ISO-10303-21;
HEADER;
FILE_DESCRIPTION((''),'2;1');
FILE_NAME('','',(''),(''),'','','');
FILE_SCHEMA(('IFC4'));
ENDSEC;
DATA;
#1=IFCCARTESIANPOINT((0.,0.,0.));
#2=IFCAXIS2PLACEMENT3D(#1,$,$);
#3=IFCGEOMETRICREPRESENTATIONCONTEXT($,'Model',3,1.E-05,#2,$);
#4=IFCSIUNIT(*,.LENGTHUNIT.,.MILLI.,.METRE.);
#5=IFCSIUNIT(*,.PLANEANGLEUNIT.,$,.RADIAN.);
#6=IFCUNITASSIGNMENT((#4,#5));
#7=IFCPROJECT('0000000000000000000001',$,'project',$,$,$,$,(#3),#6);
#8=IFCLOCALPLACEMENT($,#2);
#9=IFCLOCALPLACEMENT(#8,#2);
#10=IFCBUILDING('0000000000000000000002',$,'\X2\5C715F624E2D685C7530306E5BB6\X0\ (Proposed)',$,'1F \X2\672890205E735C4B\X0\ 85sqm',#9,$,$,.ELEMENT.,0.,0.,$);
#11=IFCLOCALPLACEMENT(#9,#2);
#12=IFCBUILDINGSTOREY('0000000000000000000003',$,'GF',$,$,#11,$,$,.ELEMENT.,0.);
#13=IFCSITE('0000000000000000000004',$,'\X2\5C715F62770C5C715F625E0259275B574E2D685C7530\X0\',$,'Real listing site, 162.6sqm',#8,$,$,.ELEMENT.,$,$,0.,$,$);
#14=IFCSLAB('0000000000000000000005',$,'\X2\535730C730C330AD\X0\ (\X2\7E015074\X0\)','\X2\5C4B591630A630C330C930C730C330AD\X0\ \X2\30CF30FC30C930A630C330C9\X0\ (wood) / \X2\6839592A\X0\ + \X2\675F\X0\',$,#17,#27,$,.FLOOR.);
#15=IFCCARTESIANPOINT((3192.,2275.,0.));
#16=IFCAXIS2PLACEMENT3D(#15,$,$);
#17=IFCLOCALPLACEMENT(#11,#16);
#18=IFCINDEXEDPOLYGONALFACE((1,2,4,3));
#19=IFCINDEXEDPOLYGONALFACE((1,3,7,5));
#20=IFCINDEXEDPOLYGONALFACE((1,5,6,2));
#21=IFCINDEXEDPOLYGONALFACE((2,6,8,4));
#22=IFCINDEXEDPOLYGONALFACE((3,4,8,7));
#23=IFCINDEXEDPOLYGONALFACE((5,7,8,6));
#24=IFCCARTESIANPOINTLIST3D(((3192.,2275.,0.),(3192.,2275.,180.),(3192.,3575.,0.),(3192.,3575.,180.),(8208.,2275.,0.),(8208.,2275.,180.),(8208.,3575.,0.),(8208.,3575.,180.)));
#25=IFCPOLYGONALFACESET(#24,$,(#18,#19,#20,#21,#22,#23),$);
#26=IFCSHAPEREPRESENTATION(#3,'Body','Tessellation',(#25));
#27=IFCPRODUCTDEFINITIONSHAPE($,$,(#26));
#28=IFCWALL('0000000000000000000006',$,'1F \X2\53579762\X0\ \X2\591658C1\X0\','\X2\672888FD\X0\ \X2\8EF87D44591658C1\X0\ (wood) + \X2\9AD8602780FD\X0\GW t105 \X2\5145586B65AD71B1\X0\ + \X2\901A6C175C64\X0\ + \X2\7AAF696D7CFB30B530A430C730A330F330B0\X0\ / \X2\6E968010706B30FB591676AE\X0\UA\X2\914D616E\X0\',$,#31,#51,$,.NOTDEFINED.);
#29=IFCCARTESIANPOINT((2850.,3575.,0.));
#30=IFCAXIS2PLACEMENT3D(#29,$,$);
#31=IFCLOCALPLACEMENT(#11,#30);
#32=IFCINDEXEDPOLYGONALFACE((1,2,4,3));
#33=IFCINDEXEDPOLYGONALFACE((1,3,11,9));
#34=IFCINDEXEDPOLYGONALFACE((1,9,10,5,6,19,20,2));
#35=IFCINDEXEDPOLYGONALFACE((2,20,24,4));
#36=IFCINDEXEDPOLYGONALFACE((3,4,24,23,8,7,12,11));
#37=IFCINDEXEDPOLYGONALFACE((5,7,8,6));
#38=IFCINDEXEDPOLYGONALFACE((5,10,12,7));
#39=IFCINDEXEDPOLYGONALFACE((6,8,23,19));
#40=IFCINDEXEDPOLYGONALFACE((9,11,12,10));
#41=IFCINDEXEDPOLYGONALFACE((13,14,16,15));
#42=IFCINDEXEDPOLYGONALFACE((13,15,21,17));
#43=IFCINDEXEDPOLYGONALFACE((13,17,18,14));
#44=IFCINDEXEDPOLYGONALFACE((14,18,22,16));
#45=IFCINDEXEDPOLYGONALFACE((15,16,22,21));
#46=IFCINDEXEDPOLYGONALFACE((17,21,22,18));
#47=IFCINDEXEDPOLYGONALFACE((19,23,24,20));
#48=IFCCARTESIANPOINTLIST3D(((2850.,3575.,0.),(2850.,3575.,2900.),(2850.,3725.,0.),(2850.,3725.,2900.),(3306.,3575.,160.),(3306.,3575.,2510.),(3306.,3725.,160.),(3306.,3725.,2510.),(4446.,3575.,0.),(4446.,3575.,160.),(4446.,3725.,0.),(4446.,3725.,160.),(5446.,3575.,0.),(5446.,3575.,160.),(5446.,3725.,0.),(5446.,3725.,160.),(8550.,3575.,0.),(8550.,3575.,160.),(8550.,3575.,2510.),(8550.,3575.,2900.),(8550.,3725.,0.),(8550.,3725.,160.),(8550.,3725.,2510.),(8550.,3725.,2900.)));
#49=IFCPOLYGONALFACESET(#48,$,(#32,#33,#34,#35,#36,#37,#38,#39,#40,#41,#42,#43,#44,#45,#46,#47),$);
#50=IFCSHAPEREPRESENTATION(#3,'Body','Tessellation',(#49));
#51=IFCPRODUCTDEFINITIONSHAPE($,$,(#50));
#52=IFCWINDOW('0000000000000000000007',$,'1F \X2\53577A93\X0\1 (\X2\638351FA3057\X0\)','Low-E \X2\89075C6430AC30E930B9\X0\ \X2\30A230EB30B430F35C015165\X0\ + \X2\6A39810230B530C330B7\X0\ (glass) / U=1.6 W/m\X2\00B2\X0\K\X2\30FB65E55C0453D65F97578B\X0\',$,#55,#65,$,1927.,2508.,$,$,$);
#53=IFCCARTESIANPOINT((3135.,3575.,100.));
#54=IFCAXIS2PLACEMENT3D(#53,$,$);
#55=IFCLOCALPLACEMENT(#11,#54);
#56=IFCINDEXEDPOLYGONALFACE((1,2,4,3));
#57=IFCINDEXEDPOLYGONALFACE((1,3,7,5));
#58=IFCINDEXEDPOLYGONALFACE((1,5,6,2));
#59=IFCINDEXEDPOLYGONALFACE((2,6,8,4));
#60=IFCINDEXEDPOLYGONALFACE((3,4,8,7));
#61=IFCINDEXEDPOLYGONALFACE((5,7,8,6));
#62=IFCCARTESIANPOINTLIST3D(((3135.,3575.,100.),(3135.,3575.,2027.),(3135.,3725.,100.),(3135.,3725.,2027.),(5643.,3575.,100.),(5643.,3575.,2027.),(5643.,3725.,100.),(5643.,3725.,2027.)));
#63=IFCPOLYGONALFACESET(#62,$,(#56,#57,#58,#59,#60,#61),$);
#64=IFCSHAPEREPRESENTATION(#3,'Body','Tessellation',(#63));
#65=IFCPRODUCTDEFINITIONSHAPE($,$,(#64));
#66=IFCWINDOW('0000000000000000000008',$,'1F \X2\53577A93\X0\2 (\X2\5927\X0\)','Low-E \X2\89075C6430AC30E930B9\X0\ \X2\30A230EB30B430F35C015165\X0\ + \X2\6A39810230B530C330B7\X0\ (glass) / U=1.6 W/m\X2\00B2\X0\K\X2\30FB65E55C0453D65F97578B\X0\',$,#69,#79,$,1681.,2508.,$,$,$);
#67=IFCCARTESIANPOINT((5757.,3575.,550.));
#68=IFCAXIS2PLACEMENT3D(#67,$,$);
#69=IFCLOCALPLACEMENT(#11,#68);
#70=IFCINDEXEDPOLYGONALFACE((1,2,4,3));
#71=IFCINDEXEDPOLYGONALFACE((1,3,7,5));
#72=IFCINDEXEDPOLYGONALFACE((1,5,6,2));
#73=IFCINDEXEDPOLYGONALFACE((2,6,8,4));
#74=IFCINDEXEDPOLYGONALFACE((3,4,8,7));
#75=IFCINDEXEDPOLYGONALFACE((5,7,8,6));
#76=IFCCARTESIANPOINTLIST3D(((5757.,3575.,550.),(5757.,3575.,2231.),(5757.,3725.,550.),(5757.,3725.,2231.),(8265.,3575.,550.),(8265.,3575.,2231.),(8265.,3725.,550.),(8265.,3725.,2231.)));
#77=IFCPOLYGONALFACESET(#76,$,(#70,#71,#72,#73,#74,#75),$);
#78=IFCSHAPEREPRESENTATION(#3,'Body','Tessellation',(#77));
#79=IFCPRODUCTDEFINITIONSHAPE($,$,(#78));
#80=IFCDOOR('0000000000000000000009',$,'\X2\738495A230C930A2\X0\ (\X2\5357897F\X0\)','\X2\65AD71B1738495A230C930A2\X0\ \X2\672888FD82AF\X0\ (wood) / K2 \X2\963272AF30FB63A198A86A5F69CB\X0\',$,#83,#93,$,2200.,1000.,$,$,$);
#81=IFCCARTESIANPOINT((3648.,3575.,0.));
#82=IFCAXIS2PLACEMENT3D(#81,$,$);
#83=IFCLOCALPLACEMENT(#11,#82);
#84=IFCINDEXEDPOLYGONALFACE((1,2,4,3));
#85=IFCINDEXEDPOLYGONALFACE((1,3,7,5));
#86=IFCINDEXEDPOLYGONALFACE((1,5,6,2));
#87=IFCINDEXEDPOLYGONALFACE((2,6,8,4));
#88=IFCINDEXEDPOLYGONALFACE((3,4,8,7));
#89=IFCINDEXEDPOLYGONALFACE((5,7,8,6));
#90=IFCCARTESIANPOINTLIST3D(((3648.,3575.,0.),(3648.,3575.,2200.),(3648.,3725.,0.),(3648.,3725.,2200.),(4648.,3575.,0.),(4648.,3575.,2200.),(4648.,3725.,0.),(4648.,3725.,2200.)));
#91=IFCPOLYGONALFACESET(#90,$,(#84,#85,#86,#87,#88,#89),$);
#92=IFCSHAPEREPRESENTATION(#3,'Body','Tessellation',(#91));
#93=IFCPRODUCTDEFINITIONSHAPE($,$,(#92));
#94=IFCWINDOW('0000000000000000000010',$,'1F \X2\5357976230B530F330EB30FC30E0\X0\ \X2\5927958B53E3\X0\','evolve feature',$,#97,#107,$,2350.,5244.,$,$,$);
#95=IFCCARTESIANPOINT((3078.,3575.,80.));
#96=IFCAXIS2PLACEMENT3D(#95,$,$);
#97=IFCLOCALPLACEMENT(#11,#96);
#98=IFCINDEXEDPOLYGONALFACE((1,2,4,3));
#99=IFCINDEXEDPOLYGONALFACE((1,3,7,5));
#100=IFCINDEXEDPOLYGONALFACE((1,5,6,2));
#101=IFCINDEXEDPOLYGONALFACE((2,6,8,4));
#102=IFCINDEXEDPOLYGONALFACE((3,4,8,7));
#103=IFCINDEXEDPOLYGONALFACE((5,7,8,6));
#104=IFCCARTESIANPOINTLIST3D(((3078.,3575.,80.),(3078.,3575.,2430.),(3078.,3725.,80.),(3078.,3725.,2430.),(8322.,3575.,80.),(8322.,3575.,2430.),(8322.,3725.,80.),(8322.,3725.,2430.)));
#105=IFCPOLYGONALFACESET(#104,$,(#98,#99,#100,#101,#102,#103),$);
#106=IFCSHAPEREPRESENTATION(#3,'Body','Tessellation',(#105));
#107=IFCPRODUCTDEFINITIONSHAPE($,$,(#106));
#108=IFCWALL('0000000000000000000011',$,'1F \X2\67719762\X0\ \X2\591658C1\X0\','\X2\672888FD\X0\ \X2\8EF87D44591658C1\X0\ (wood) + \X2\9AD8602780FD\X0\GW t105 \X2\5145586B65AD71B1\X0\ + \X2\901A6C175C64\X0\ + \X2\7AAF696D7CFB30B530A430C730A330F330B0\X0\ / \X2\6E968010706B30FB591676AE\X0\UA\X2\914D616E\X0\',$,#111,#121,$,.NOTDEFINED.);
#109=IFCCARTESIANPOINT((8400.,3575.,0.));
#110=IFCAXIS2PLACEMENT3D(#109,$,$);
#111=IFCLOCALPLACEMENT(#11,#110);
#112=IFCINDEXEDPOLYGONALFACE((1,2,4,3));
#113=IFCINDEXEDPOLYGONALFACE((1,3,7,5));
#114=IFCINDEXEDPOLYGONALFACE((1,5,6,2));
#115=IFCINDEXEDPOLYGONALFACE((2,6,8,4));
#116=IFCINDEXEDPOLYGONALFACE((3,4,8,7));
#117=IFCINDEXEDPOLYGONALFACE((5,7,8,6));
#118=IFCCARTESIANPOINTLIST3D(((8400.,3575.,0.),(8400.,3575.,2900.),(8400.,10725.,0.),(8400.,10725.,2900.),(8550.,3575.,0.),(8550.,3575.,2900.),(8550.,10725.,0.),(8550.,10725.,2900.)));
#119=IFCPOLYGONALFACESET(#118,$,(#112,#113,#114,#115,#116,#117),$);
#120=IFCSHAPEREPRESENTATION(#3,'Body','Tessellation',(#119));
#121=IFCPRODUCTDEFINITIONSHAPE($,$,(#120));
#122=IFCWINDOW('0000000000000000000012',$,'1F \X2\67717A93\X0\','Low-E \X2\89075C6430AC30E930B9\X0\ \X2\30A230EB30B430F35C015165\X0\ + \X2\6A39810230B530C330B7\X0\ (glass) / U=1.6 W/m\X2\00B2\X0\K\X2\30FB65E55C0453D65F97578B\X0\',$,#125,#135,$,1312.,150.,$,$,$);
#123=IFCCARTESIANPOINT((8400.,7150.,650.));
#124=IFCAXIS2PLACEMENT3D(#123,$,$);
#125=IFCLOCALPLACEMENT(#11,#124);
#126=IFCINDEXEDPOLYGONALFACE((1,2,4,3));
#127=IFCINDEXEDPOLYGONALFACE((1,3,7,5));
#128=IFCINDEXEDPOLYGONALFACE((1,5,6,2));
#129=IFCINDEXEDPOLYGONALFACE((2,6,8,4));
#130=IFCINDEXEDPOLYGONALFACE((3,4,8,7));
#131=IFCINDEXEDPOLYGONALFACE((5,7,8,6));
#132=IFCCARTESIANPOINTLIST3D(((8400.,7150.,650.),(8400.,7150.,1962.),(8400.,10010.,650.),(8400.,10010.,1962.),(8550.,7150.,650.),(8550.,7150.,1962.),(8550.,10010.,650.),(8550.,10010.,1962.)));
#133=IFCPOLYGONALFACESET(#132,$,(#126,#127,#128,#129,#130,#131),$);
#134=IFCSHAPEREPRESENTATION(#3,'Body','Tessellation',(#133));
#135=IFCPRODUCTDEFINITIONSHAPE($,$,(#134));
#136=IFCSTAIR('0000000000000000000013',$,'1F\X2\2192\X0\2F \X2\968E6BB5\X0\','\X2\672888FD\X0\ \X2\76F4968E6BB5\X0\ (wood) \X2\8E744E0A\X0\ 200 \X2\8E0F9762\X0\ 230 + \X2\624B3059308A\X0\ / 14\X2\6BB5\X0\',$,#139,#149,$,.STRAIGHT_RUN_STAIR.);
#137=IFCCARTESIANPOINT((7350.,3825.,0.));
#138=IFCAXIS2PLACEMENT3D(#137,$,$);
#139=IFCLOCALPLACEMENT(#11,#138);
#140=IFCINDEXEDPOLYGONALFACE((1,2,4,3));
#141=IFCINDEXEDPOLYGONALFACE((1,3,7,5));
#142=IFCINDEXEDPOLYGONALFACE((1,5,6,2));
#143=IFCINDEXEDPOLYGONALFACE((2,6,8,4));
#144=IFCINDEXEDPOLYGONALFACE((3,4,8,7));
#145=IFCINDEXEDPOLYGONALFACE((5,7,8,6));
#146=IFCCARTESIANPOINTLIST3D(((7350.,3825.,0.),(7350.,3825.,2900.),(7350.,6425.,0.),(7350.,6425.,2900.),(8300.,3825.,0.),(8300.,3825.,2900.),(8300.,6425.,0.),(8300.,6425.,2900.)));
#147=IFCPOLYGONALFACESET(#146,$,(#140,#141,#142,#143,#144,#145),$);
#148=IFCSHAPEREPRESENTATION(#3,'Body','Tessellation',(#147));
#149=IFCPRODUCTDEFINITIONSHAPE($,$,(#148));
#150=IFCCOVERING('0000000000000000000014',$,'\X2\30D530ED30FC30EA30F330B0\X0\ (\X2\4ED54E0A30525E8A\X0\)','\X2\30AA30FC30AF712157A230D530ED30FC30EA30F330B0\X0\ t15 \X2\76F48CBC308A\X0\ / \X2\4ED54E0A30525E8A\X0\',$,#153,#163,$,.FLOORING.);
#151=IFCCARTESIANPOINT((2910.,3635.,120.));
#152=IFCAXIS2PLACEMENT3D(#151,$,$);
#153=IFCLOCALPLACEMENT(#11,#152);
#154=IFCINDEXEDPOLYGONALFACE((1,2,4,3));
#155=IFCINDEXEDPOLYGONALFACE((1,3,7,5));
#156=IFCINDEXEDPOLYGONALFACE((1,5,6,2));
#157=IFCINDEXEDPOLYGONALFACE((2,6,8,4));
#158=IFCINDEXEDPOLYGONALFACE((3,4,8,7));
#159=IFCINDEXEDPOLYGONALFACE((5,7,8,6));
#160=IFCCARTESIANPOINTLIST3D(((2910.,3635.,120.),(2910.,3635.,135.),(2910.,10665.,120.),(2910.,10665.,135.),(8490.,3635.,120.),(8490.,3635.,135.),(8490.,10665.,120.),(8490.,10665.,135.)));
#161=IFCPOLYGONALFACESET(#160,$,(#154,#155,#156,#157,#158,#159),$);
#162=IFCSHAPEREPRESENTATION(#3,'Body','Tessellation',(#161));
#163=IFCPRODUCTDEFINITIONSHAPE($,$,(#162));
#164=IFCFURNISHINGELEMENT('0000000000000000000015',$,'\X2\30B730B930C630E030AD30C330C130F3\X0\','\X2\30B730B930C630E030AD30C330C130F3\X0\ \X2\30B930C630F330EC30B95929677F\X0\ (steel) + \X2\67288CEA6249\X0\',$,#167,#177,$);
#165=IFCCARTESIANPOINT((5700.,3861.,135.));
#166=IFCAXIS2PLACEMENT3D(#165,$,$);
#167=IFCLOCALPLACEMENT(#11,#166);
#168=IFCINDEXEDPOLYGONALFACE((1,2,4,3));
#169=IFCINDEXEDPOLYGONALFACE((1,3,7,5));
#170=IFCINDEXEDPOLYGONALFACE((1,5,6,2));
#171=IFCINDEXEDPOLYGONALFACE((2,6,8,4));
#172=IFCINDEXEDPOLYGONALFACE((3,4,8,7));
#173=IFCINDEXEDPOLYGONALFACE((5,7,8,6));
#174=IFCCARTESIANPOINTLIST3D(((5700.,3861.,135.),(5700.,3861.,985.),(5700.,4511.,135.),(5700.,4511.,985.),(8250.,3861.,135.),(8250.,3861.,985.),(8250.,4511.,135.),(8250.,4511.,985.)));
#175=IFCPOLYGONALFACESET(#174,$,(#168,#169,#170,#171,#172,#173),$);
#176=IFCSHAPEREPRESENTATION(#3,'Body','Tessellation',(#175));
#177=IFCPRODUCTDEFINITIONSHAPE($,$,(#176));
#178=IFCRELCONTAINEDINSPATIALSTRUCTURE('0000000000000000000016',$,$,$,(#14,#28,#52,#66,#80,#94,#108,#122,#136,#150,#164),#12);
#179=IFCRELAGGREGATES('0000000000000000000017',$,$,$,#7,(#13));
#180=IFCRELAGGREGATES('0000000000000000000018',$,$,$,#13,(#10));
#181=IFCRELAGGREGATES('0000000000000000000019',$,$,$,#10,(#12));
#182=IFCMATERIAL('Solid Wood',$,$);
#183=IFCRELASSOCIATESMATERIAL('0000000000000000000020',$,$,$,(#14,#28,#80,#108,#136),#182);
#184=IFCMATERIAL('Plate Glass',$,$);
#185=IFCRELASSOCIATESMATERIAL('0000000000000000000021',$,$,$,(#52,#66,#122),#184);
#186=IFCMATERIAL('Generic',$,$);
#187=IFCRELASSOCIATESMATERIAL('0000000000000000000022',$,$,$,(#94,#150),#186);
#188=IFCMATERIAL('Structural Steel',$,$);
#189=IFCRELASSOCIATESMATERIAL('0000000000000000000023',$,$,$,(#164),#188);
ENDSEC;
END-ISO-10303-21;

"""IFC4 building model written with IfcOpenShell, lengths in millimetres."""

from ifc_helpers import new_model, si_unit, frame, frame_2d, origin, place, context, project, spatial, rectangle, extrude, material, element, fill, save


model = new_model("IFC4")

# Units and contexts
model_context = context("Model", 3, precision=1e-05, world=origin())
ifc_project = project(units=[si_unit("LENGTHUNIT", "METRE", prefix="MILLI"), si_unit("PLANEANGLEUNIT", "RADIAN")], contexts=[model_context])

# Site, building, storey
site_placement = place(None, origin())
site = spatial("IfcSite", under=ifc_project, at=site_placement, Name="山形県山形市大字中桜田", ObjectType="Real listing site, 162.6sqm", CompositionType="ELEMENT", RefElevation=0.0)
building_placement = place(site_placement, origin())
building = spatial("IfcBuilding", under=site, at=building_placement, Name="山形中桜田の家 (Proposed)", ObjectType="1F 木造平屋 85sqm", CompositionType="ELEMENT", ElevationOfRefHeight=0.0, ElevationOfTerrain=0.0)
storey_placement = place(building_placement, origin())
storey = spatial("IfcBuildingStorey", under=building, at=storey_placement, Name="GF", CompositionType="ELEMENT", Elevation=0.0)

# Slab
ifc_material_1 = material(Name="Solid Wood")
slab_1_placement = place(storey_placement, frame((3192.0, 2275.0, 0.0)))
element("IfcSlab", 1, at=slab_1_placement, inside=storey, material=ifc_material_1, Name="南デッキ (縁側)", Description="屋外ウッドデッキ ハードウッド (wood) / 根太 + 束", PredefinedType="FLOOR", context=model_context, shape_type="SweptSolid", body=[
    extrude(rectangle(XDim=5016.0, YDim=1300.0, at=frame_2d((2508.0, 650.0))), frame((3192.0, 2275.0, 0.0)), (0.0, 0.0, 1.0), 180.0),
])
ifc_material_2 = material(Name="Generic")

# Wall, openings, windows, door
wall_1_placement = place(storey_placement, frame((2850.0, 3575.0, 0.0)))
wall_1 = element("IfcWall", 2, at=wall_1_placement, inside=storey, material=ifc_material_1, Name="1F 南面 外壁", Description="木製 軸組外壁 (wood) + 高性能GW t105 充填断熱 + 通気層 + 窯業系サイディング / 準耐火・外皮UA配慮", PredefinedType="NOTDEFINED", context=model_context, shape_type="SweptSolid", body=[
    extrude(rectangle(XDim=5700.0, YDim=150.0, at=frame_2d((2850.0, 75.0))), frame((2850.0, 3575.0, 0.0)), (0.0, 0.0, 1.0), 2900.0),
])
opening_1_placement = place(storey_placement, frame((3135.0, 3575.0, 100.0)))
opening_1 = element("IfcOpeningElement", 3, at=opening_1_placement, cuts=wall_1, PredefinedType="NOTDEFINED", context=model_context, shape_type="SweptSolid", body=[
    extrude(rectangle(XDim=2508.0, YDim=150.0, at=frame_2d((1254.0, 75.0))), frame((3135.0, 3575.0, 100.0)), (0.0, 0.0, 1.0), 1927.0),
])
opening_2_placement = place(storey_placement, frame((5757.0, 3575.0, 550.0)))
opening_2 = element("IfcOpeningElement", 4, at=opening_2_placement, cuts=wall_1, PredefinedType="NOTDEFINED", context=model_context, shape_type="SweptSolid", body=[
    extrude(rectangle(XDim=2508.0, YDim=150.0, at=frame_2d((1254.0, 75.0))), frame((5757.0, 3575.0, 550.0)), (0.0, 0.0, 1.0), 1681.0),
])
opening_3_placement = place(storey_placement, frame((3648.0, 3575.0, 0.0)))
opening_3 = element("IfcOpeningElement", 5, at=opening_3_placement, cuts=wall_1, PredefinedType="NOTDEFINED", context=model_context, shape_type="SweptSolid", body=[
    extrude(rectangle(XDim=1000.0, YDim=150.0, at=frame_2d((500.0, 75.0))), frame((3648.0, 3575.0, 0.0)), (0.0, 0.0, 1.0), 2200.0),
])
opening_4_placement = place(storey_placement, frame((3078.0, 3575.0, 80.0)))
opening_4 = element("IfcOpeningElement", 6, at=opening_4_placement, cuts=wall_1, PredefinedType="NOTDEFINED", context=model_context, shape_type="SweptSolid", body=[
    extrude(rectangle(XDim=5244.0, YDim=150.0, at=frame_2d((2622.0, 75.0))), frame((3078.0, 3575.0, 80.0)), (0.0, 0.0, 1.0), 2350.0),
])
ifc_material_3 = material(Name="Plate Glass")
window_1_placement = place(storey_placement, frame((3135.0, 3575.0, 100.0)))
window_1 = element("IfcWindow", 7, at=window_1_placement, inside=storey, material=ifc_material_3, Name="1F 南窓1 (掃出し)", Description="Low-E 複層ガラス アルゴン封入 + 樹脂サッシ (glass) / U=1.6 W/m²K・日射取得型", OverallHeight=1927.0, OverallWidth=2508.0, context=model_context, shape_type="SweptSolid", body=[
    extrude(rectangle(XDim=2508.0, YDim=150.0, at=frame_2d((1254.0, 75.0))), frame((3135.0, 3575.0, 100.0)), (0.0, 0.0, 1.0), 1927.0),
])
fill(opening_1, window_1)
window_2_placement = place(storey_placement, frame((5757.0, 3575.0, 550.0)))
window_2 = element("IfcWindow", 8, at=window_2_placement, inside=storey, material=ifc_material_3, Name="1F 南窓2 (大)", Description="Low-E 複層ガラス アルゴン封入 + 樹脂サッシ (glass) / U=1.6 W/m²K・日射取得型", OverallHeight=1681.0, OverallWidth=2508.0, context=model_context, shape_type="SweptSolid", body=[
    extrude(rectangle(XDim=2508.0, YDim=150.0, at=frame_2d((1254.0, 75.0))), frame((5757.0, 3575.0, 550.0)), (0.0, 0.0, 1.0), 1681.0),
])
fill(opening_2, window_2)
door_placement = place(storey_placement, frame((3648.0, 3575.0, 0.0)))
door = element("IfcDoor", 9, at=door_placement, inside=storey, material=ifc_material_1, Name="玄関ドア (南西)", Description="断熱玄関ドア 木製芯 (wood) / K2 防犯・採風機構", OverallHeight=2200.0, OverallWidth=1000.0, context=model_context, shape_type="SweptSolid", body=[
    extrude(rectangle(XDim=1000.0, YDim=150.0, at=frame_2d((500.0, 75.0))), frame((3648.0, 3575.0, 0.0)), (0.0, 0.0, 1.0), 2200.0),
])
fill(opening_3, door)
window_3_placement = place(storey_placement, frame((3078.0, 3575.0, 80.0)))
window_3 = element("IfcWindow", 10, at=window_3_placement, inside=storey, material=ifc_material_2, Name="1F 南面サンルーム 大開口", Description="evolve feature", OverallHeight=2350.0, OverallWidth=5244.0, context=model_context, shape_type="SweptSolid", body=[
    extrude(rectangle(XDim=5244.0, YDim=150.0, at=frame_2d((2622.0, 75.0))), frame((3078.0, 3575.0, 80.0)), (0.0, 0.0, 1.0), 2350.0),
])
fill(opening_4, window_3)

# Wall, opening, window
wall_2_placement = place(storey_placement, frame((8400.0, 3575.0, 0.0)))
wall_2 = element("IfcWall", 11, at=wall_2_placement, inside=storey, material=ifc_material_1, Name="1F 東面 外壁", Description="木製 軸組外壁 (wood) + 高性能GW t105 充填断熱 + 通気層 + 窯業系サイディング / 準耐火・外皮UA配慮", PredefinedType="NOTDEFINED", context=model_context, shape_type="SweptSolid", body=[
    extrude(rectangle(XDim=150.0, YDim=7150.0, at=frame_2d((75.0, 3575.0))), frame((8400.0, 3575.0, 0.0)), (0.0, 0.0, 1.0), 2900.0),
])
opening_5_placement = place(storey_placement, frame((8400.0, 7150.0, 650.0)))
opening_5 = element("IfcOpeningElement", 12, at=opening_5_placement, cuts=wall_2, PredefinedType="NOTDEFINED", context=model_context, shape_type="SweptSolid", body=[
    extrude(rectangle(XDim=150.0, YDim=2860.0, at=frame_2d((75.0, 1430.0))), frame((8400.0, 7150.0, 650.0)), (0.0, 0.0, 1.0), 1312.0),
])
window_4_placement = place(storey_placement, frame((8400.0, 7150.0, 650.0)))
window_4 = element("IfcWindow", 13, at=window_4_placement, inside=storey, material=ifc_material_3, Name="1F 東窓", Description="Low-E 複層ガラス アルゴン封入 + 樹脂サッシ (glass) / U=1.6 W/m²K・日射取得型", OverallHeight=1312.0, OverallWidth=150.0, context=model_context, shape_type="SweptSolid", body=[
    extrude(rectangle(XDim=150.0, YDim=2860.0, at=frame_2d((75.0, 1430.0))), frame((8400.0, 7150.0, 650.0)), (0.0, 0.0, 1.0), 1312.0),
])
fill(opening_5, window_4)

# Stair
stair_placement = place(storey_placement, frame((7350.0, 3825.0, 0.0)))
element("IfcStair", 14, at=stair_placement, inside=storey, material=ifc_material_1, Name="1F→2F 階段", Description="木製 直階段 (wood) 蹴上 200 踏面 230 + 手すり / 14段", PredefinedType="STRAIGHT_RUN_STAIR", context=model_context, shape_type="SweptSolid", body=[
    extrude(rectangle(XDim=950.0, YDim=2600.0, at=frame_2d((475.0, 1300.0))), frame((7350.0, 3825.0, 0.0)), (0.0, 0.0, 1.0), 2900.0),
])

# Covering
covering_placement = place(storey_placement, frame((2910.0, 3635.0, 120.0)))
element("IfcCovering", 15, at=covering_placement, inside=storey, material=ifc_material_2, Name="フローリング (仕上げ床)", Description="オーク無垢フローリング t15 直貼り / 仕上げ床", PredefinedType="FLOORING", context=model_context, shape_type="SweptSolid", body=[
    extrude(rectangle(XDim=5580.0, YDim=7030.0, at=frame_2d((2790.0, 3515.0))), frame((2910.0, 3635.0, 120.0)), (0.0, 0.0, 1.0), 15.0),
])

# Furnishing element
ifc_material_4 = material(Name="Structural Steel")
furnishing_placement = place(storey_placement, frame((5700.0, 3861.0, 135.0)))
element("IfcFurnishingElement", 16, at=furnishing_placement, inside=storey, material=ifc_material_4, Name="システムキッチン", Description="システムキッチン ステンレス天板 (steel) + 木質扉", context=model_context, shape_type="SweptSolid", body=[
    extrude(rectangle(XDim=2550.0, YDim=650.0, at=frame_2d((1275.0, 325.0))), frame((5700.0, 3861.0, 135.0)), (0.0, 0.0, 1.0), 850.0),
])

save(model, "model.ifc")
